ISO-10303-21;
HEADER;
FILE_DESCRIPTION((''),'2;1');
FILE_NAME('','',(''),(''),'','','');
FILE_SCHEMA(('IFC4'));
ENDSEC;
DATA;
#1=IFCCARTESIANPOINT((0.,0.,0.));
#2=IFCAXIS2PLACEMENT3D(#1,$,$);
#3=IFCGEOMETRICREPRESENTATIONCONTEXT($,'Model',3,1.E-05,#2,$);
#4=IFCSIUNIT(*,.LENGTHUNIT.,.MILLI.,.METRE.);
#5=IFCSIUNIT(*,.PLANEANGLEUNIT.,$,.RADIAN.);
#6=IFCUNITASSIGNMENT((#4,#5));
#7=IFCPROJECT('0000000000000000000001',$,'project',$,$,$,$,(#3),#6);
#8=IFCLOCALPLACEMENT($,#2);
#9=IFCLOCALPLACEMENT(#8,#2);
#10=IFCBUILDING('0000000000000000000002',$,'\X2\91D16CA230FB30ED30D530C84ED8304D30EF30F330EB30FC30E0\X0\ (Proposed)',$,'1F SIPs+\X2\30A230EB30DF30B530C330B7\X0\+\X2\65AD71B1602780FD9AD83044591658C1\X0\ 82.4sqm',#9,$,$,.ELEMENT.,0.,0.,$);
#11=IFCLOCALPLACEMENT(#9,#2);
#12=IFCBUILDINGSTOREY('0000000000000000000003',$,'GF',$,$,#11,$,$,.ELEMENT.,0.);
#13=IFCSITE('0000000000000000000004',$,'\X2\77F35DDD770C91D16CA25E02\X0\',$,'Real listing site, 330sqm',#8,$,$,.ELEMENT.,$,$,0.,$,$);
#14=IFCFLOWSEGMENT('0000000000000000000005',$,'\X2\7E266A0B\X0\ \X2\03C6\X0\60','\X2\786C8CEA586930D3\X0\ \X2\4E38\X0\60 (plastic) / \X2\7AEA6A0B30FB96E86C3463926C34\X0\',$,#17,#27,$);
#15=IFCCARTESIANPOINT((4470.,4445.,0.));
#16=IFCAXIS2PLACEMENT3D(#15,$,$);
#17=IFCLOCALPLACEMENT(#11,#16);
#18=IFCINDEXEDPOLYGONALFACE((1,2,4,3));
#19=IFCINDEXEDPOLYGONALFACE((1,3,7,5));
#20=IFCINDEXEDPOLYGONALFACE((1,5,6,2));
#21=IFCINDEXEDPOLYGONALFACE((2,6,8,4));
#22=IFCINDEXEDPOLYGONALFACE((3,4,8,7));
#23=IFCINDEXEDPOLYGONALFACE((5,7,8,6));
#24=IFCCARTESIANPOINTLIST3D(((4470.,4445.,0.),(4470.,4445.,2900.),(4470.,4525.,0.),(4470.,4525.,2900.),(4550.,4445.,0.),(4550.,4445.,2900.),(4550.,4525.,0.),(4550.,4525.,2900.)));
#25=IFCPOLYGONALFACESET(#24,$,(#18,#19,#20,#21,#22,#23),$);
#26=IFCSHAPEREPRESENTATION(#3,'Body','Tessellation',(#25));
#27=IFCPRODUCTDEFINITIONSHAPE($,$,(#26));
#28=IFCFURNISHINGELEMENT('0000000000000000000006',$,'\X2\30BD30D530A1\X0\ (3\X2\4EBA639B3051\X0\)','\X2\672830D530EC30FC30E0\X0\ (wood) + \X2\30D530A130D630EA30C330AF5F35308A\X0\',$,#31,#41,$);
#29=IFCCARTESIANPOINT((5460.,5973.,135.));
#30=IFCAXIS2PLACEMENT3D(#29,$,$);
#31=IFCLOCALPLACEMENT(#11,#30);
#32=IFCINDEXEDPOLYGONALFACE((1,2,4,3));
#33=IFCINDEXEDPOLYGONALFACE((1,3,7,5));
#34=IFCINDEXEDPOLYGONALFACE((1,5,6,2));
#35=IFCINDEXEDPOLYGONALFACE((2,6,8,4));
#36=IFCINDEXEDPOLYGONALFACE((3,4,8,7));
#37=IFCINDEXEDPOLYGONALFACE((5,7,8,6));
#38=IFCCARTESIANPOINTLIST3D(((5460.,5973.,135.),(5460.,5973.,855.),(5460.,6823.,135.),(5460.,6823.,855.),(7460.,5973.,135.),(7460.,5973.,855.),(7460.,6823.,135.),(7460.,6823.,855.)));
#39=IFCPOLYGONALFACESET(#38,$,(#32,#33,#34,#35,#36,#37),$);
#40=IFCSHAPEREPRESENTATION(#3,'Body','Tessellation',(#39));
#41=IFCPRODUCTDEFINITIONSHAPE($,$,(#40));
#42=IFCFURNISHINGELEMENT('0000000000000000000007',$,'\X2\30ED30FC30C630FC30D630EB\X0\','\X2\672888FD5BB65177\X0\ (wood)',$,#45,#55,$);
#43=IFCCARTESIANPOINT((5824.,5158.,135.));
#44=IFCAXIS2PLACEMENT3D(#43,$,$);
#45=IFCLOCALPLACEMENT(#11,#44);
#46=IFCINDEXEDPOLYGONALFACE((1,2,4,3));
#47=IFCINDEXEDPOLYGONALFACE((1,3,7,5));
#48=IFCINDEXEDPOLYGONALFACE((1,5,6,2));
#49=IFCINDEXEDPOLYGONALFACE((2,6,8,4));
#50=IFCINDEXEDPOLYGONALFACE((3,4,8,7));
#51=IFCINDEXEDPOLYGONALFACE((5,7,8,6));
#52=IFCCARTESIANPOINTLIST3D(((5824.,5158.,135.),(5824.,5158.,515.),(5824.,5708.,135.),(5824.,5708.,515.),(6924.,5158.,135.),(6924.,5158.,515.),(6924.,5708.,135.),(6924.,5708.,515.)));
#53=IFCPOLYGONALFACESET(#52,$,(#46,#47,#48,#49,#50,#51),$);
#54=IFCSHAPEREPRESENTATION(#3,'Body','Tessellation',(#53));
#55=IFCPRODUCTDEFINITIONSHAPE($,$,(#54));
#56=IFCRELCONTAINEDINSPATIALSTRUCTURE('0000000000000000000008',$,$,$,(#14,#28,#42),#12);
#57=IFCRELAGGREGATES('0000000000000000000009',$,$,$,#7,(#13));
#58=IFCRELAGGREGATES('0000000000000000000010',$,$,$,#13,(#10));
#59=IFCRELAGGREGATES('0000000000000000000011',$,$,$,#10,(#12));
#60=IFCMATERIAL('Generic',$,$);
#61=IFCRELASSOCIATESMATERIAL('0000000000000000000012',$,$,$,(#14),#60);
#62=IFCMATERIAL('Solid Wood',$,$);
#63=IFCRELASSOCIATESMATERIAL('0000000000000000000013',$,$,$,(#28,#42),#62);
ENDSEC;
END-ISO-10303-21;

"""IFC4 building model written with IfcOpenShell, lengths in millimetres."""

from ifc_helpers import new_model, si_unit, frame, frame_2d, origin, place, context, project, spatial, rectangle, extrude, material, element, save


model = new_model("IFC4")

# Units and contexts
model_context = context("Model", 3, precision=1e-05, world=origin())
ifc_project = project(units=[si_unit("LENGTHUNIT", "METRE", prefix="MILLI"), si_unit("PLANEANGLEUNIT", "RADIAN")], contexts=[model_context])

# Site, building, storey
site_placement = place(None, origin())
site = spatial("IfcSite", under=ifc_project, at=site_placement, Name="石川県金沢市", ObjectType="Real listing site, 330sqm", CompositionType="ELEMENT", RefElevation=0.0)
building_placement = place(site_placement, origin())
building = spatial("IfcBuilding", under=site, at=building_placement, Name="金沢・ロフト付きワンルーム (Proposed)", ObjectType="1F SIPs+アルミサッシ+断熱性能高い外壁 82.4sqm", CompositionType="ELEMENT", ElevationOfRefHeight=0.0, ElevationOfTerrain=0.0)
storey_placement = place(building_placement, origin())
storey = spatial("IfcBuildingStorey", under=building, at=storey_placement, Name="GF", CompositionType="ELEMENT", Elevation=0.0)

# Shared definitions
ifc_material_1 = material(Name="Solid Wood")

# Shared definitions
ifc_material_2 = material(Name="Generic")

# Flow segment
flow_segment_1_placement = place(storey_placement, frame((4470.0, 4445.0, 0.0)))
element("IfcFlowSegment", 1, at=flow_segment_1_placement, inside=storey, material=ifc_material_2, Name="縦樋 φ60", Description="硬質塩ビ 丸60 (plastic) / 竪樋・雨水排水", context=model_context, shape_type="SweptSolid", body=[
    extrude(rectangle(XDim=80.0, YDim=80.0, at=frame_2d((40.0, 40.0))), frame((4470.0, 4445.0, 0.0)), (0.0, 0.0, 1.0), 2900.0),
])

# Furnishing elements
furnishing_1_placement = place(storey_placement, frame((5460.0, 5973.0, 135.0)))
element("IfcFurnishingElement", 2, at=furnishing_1_placement, inside=storey, material=ifc_material_1, Name="ソファ (3人掛け)", Description="木フレーム (wood) + ファブリック張り", context=model_context, shape_type="SweptSolid", body=[
    extrude(rectangle(XDim=2000.0, YDim=850.0, at=frame_2d((1000.0, 425.0))), frame((5460.0, 5973.0, 135.0)), (0.0, 0.0, 1.0), 720.0),
])
furnishing_2_placement = place(storey_placement, frame((5824.0, 5158.0, 135.0)))
element("IfcFurnishingElement", 3, at=furnishing_2_placement, inside=storey, material=ifc_material_1, Name="ローテーブル", Description="木製家具 (wood)", context=model_context, shape_type="SweptSolid", body=[
    extrude(rectangle(XDim=1100.0, YDim=550.0, at=frame_2d((550.0, 275.0))), frame((5824.0, 5158.0, 135.0)), (0.0, 0.0, 1.0), 380.0),
])

save(model, "model.ifc")
